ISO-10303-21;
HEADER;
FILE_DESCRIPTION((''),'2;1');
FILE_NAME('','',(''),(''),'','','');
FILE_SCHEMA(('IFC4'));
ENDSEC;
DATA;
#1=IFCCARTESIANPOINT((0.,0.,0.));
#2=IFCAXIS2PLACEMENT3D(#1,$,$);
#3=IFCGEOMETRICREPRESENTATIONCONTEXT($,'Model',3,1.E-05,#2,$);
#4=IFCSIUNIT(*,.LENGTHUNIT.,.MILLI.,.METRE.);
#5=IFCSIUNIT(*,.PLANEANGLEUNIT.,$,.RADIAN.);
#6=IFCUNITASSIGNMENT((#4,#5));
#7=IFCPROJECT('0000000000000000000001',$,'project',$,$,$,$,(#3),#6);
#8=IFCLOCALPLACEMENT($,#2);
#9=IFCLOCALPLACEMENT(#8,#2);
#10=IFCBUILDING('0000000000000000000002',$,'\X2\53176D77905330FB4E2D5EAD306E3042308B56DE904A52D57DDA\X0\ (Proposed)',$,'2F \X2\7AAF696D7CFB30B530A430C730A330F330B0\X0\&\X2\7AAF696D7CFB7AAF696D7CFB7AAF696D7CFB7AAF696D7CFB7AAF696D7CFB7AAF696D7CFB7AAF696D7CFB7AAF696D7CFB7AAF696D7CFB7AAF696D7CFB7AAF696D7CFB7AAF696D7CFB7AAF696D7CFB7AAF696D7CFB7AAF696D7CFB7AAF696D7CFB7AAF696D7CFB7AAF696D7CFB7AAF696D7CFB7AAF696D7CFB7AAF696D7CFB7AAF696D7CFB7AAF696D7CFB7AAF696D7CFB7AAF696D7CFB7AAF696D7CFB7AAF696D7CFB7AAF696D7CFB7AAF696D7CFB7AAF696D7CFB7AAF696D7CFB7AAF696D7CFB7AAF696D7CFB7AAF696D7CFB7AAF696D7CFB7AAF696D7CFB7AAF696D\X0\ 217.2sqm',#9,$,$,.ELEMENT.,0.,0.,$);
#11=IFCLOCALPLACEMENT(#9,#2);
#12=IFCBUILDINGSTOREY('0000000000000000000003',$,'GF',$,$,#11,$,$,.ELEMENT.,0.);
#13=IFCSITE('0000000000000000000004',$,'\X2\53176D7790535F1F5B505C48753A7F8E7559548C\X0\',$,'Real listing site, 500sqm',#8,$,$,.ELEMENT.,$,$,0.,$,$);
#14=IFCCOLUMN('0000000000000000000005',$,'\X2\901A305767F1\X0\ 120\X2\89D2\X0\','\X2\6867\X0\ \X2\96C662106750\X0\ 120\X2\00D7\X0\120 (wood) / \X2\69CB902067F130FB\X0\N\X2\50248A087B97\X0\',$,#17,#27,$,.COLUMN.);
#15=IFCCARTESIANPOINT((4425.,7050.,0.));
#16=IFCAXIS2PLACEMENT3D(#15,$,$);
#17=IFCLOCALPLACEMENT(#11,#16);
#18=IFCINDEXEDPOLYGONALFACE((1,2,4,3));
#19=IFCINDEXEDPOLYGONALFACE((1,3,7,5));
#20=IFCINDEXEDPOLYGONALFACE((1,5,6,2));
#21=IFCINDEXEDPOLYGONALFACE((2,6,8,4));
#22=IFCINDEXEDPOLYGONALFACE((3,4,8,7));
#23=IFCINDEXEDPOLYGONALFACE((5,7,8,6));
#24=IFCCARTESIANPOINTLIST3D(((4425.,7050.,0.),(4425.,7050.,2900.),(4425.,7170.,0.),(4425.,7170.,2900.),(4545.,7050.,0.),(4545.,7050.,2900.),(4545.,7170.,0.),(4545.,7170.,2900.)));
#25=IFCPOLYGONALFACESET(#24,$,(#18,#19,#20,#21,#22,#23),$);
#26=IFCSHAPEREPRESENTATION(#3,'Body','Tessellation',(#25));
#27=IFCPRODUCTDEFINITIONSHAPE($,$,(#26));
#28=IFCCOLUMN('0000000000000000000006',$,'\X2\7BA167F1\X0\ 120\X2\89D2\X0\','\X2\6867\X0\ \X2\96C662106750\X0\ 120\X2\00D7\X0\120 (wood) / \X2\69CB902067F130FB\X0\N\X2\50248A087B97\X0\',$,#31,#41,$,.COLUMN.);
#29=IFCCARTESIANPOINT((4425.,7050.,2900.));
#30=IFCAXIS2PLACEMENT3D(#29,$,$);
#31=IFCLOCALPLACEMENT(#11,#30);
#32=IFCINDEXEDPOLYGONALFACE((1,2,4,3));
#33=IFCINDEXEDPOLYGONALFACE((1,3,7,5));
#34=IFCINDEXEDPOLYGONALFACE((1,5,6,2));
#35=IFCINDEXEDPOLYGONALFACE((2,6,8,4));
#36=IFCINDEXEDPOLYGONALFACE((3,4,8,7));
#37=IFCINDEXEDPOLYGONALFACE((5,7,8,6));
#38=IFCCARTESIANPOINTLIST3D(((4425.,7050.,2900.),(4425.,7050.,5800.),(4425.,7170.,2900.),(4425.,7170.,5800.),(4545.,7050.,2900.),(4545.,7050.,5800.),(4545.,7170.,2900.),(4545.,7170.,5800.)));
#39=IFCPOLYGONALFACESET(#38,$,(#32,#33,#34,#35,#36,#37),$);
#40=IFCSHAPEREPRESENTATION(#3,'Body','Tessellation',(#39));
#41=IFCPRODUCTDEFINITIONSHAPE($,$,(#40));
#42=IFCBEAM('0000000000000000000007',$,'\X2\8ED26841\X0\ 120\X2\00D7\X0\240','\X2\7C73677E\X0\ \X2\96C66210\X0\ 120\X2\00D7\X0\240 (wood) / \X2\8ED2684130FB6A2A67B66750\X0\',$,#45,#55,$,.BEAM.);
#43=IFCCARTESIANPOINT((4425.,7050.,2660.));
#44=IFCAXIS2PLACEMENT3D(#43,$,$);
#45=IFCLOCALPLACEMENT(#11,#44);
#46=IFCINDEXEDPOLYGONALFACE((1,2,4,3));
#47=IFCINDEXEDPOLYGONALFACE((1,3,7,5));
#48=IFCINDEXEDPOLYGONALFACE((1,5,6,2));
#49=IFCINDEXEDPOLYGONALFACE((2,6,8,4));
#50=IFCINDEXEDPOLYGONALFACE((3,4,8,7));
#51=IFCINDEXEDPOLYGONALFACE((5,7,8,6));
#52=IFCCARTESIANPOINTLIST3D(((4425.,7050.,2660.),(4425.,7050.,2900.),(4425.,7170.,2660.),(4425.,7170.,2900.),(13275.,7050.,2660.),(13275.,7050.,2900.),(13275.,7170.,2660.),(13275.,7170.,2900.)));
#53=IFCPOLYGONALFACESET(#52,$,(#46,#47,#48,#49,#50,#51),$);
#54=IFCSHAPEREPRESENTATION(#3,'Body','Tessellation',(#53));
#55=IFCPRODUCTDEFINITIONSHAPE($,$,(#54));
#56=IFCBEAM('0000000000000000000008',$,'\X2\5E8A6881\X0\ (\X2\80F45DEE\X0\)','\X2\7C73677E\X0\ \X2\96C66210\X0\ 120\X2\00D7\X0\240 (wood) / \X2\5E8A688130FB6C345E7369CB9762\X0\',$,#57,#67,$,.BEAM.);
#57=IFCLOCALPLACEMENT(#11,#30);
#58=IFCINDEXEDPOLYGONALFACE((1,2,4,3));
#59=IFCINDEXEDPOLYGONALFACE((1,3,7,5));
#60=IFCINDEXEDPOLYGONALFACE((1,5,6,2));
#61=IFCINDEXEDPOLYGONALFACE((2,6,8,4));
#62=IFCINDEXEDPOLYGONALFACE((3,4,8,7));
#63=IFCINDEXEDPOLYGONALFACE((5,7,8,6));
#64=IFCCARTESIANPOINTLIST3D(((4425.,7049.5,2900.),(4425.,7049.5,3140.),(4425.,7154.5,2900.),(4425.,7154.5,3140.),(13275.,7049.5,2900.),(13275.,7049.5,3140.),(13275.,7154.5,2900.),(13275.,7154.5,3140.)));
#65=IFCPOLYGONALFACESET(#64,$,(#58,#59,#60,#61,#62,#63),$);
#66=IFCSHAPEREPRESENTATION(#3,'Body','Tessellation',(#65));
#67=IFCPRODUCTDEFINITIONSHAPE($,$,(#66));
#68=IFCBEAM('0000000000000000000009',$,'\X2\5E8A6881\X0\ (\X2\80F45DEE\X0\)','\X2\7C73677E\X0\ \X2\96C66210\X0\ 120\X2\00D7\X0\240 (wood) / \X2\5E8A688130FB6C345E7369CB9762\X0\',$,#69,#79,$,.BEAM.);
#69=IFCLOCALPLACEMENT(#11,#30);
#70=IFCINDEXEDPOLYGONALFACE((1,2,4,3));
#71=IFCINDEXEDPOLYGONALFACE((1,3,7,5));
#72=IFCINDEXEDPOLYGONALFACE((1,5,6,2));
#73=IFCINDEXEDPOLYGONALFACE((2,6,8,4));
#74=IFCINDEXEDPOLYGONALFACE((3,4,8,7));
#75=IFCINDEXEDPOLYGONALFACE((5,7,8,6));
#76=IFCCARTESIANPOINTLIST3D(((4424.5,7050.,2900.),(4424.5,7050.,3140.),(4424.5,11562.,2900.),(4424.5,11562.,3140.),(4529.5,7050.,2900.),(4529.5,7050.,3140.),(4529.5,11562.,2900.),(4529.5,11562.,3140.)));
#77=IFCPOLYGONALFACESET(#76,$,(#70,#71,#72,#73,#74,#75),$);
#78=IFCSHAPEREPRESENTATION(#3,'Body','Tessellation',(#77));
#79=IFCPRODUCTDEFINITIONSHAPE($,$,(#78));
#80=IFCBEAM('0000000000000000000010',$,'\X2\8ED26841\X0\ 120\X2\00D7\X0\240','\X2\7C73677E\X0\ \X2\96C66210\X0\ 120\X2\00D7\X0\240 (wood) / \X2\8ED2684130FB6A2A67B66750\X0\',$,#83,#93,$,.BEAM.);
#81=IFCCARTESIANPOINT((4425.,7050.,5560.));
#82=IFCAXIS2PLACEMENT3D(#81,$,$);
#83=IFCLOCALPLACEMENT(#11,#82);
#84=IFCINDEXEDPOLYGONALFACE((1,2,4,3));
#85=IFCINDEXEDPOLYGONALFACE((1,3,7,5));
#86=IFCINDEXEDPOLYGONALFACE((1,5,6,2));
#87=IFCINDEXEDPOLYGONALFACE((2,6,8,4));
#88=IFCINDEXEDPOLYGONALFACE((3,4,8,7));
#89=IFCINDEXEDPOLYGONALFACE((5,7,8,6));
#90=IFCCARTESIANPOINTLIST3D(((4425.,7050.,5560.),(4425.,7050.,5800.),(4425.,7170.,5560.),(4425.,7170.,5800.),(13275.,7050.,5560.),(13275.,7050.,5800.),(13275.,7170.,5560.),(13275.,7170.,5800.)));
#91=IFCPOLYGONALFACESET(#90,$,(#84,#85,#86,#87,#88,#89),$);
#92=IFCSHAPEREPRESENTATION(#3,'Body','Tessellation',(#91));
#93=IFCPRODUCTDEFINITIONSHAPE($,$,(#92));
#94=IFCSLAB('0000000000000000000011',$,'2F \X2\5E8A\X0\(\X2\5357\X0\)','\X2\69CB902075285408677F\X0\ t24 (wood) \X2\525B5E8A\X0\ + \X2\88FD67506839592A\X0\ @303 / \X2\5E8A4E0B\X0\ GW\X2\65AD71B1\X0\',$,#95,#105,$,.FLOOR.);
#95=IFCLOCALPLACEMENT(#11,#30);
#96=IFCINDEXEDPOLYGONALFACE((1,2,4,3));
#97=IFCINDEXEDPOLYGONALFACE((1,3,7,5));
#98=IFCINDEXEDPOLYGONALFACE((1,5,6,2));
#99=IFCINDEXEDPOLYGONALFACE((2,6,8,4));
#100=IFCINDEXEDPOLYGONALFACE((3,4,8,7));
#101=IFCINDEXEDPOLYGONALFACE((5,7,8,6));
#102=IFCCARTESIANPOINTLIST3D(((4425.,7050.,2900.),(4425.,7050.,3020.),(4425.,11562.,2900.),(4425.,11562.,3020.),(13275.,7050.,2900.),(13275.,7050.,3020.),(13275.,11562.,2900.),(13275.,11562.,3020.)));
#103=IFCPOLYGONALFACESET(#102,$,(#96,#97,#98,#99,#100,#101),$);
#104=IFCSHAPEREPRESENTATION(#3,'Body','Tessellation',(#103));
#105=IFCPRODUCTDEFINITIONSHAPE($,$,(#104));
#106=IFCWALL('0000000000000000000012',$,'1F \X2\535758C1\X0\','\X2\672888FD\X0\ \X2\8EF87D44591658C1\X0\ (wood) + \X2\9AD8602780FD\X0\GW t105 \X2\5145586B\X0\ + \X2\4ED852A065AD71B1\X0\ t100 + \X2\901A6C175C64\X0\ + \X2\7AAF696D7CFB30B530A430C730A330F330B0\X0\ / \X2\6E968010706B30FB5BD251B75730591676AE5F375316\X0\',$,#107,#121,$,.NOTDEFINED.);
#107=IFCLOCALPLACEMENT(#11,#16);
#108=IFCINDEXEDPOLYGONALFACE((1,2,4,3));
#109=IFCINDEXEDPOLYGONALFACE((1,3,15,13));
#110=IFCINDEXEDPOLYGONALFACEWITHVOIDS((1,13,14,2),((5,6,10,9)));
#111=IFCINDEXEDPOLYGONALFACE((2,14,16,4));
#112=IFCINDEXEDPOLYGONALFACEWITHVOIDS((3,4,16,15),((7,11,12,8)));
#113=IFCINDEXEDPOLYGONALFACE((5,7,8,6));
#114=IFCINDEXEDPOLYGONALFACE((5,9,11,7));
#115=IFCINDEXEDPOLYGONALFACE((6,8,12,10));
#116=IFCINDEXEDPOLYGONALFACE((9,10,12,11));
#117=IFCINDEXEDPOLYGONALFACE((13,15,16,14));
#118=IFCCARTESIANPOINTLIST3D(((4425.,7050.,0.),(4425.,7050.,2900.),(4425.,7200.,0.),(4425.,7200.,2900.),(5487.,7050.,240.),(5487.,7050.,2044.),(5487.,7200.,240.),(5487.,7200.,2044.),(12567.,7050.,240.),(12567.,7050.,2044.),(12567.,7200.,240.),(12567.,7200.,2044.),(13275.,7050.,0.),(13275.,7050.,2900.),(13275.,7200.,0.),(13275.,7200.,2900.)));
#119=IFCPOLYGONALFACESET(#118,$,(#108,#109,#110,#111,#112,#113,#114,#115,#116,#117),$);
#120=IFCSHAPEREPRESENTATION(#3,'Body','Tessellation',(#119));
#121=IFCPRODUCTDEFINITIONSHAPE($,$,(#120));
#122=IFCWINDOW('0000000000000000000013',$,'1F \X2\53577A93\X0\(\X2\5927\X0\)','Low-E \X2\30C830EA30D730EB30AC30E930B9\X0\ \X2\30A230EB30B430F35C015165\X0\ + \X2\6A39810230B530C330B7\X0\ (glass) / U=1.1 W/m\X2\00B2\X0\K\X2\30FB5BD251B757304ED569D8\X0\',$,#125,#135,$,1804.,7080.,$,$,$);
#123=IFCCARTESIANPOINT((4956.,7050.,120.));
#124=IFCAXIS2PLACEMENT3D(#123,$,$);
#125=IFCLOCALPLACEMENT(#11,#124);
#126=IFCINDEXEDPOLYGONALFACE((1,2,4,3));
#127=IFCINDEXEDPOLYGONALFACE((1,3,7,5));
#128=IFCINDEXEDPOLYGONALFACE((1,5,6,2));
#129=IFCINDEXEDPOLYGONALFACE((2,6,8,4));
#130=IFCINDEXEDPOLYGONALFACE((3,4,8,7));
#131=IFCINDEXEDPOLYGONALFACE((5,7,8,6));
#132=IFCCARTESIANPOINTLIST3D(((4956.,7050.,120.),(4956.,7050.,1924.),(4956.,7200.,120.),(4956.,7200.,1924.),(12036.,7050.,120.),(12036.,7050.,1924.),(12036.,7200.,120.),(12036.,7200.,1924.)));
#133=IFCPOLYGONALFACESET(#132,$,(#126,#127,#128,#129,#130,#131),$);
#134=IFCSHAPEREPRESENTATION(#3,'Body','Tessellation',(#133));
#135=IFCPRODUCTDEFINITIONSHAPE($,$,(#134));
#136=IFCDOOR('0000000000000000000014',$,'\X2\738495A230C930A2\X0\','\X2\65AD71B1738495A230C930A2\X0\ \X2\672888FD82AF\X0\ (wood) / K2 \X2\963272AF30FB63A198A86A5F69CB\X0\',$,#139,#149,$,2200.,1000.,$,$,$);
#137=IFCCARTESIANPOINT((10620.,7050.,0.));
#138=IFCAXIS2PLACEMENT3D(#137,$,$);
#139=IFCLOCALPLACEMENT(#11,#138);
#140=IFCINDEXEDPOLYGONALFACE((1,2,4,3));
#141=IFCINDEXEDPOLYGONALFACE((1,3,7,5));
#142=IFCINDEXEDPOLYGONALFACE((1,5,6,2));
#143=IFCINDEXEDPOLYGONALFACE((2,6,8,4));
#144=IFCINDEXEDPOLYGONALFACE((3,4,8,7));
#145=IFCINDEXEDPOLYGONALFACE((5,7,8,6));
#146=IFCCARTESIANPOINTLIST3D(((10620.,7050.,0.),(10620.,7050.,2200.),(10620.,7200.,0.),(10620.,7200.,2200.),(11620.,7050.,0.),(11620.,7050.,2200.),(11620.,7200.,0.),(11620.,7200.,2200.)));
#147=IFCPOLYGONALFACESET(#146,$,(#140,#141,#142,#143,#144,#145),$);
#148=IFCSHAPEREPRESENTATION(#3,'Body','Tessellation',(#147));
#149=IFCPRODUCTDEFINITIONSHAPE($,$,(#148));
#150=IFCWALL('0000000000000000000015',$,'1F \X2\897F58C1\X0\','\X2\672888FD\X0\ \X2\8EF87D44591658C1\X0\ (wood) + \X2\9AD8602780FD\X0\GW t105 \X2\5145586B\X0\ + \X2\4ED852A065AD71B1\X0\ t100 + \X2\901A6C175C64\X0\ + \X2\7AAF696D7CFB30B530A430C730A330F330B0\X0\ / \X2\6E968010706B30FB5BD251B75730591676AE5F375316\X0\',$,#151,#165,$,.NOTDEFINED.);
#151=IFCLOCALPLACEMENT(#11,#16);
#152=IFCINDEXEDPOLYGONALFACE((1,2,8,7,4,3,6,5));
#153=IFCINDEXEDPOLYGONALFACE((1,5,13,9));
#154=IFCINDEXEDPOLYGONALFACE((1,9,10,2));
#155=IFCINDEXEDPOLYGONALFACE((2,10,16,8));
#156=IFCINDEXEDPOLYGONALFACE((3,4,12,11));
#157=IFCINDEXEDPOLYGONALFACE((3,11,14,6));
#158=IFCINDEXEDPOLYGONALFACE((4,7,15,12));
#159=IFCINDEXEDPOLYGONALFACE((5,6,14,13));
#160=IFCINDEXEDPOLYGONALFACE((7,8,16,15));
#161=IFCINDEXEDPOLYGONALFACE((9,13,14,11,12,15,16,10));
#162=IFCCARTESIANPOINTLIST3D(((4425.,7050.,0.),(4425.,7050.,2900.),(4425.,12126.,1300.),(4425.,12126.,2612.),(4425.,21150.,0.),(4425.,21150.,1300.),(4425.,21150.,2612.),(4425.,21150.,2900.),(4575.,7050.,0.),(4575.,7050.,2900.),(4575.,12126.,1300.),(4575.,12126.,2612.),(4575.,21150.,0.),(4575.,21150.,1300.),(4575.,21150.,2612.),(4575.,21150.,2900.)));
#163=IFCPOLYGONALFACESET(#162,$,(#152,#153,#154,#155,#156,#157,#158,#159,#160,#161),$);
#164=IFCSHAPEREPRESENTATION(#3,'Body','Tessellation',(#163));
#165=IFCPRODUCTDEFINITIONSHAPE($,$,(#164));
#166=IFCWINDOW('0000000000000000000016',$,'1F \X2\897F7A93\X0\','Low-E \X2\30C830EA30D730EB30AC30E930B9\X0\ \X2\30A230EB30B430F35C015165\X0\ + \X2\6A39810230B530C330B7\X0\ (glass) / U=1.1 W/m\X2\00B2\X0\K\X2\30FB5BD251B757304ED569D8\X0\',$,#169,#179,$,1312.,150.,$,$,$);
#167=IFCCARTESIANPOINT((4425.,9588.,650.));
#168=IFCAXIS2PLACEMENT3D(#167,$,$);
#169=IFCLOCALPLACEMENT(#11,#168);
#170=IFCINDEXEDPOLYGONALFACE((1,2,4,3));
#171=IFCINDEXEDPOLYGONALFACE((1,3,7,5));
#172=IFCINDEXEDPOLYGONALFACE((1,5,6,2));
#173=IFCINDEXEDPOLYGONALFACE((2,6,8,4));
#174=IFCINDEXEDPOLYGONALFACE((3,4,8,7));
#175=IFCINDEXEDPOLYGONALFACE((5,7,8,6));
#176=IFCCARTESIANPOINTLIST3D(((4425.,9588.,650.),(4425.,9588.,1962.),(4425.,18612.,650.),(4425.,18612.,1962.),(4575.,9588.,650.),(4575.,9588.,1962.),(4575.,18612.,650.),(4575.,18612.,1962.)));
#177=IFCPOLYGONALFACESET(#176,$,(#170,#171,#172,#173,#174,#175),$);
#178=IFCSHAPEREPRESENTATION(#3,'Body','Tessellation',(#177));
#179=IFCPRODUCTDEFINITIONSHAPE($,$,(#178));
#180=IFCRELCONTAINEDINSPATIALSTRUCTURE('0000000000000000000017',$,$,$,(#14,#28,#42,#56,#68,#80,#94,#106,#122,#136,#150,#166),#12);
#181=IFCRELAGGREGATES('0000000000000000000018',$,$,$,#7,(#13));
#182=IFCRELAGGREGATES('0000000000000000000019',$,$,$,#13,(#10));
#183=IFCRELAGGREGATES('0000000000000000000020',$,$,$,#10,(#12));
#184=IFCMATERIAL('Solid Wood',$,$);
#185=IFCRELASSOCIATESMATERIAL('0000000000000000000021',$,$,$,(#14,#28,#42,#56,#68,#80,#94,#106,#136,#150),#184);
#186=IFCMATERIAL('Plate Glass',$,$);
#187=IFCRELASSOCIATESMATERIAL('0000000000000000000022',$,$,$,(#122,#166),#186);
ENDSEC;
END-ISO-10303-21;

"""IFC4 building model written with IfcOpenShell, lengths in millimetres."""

from ifc_helpers import new_model, si_unit, frame, frame_2d, origin, place, context, project, spatial, rectangle, extrude, material, element, fill, save


model = new_model("IFC4")

# Units and contexts
model_context = context("Model", 3, precision=1e-05, world=origin())
ifc_project = project(units=[si_unit("LENGTHUNIT", "METRE", prefix="MILLI"), si_unit("PLANEANGLEUNIT", "RADIAN")], contexts=[model_context])

# Site, building, storey
site_placement = place(None, origin())
site = spatial("IfcSite", under=ifc_project, at=site_placement, Name="北海道弟子屈町美留和", ObjectType="Real listing site, 500sqm", CompositionType="ELEMENT", RefElevation=0.0)
building_placement = place(site_placement, origin())
building = spatial("IfcBuilding", under=site, at=building_placement, Name="北海道・中庭のある回遊動線 (Proposed)", ObjectType="2F 窯業系サイディング&窯業系窯業系窯業系窯業系窯業系窯業系窯業系窯業系窯業系窯業系窯業系窯業系窯業系窯業系窯業系窯業系窯業系窯業系窯業系窯業系窯業系窯業系窯業系窯業系窯業系窯業系窯業系窯業系窯業系窯業系窯業系窯業系窯業系窯業系窯業系窯業系窯業 217.2sqm", CompositionType="ELEMENT", ElevationOfRefHeight=0.0, ElevationOfTerrain=0.0)
storey_placement = place(building_placement, origin())
storey = spatial("IfcBuildingStorey", under=building, at=storey_placement, Name="GF", CompositionType="ELEMENT", Elevation=0.0)

# Columns
ifc_material_1 = material(Name="Solid Wood")
column_1_placement = place(storey_placement, frame((4425.0, 7050.0, 0.0)))
element("IfcColumn", 1, at=column_1_placement, inside=storey, material=ifc_material_1, Name="通し柱 120角", Description="桧 集成材 120×120 (wood) / 構造柱・N値計算", PredefinedType="COLUMN", context=model_context, shape_type="SweptSolid", body=[
    extrude(rectangle(XDim=120.0, YDim=120.0, at=frame_2d((60.0, 60.0))), frame((4425.0, 7050.0, 0.0)), (0.0, 0.0, 1.0), 2900.0),
])
column_2_placement = place(storey_placement, frame((4425.0, 7050.0, 2900.0)))
element("IfcColumn", 2, at=column_2_placement, inside=storey, material=ifc_material_1, Name="管柱 120角", Description="桧 集成材 120×120 (wood) / 構造柱・N値計算", PredefinedType="COLUMN", context=model_context, shape_type="SweptSolid", body=[
    extrude(rectangle(XDim=120.0, YDim=120.0, at=frame_2d((60.0, 60.0))), frame((4425.0, 7050.0, 2900.0)), (0.0, 0.0, 1.0), 2900.0),
])

# Beams
beam_1_placement = place(storey_placement, frame((4425.0, 7050.0, 2660.0)))
element("IfcBeam", 3, at=beam_1_placement, inside=storey, material=ifc_material_1, Name="軒桁 120×240", Description="米松 集成 120×240 (wood) / 軒桁・横架材", PredefinedType="BEAM", context=model_context, shape_type="SweptSolid", body=[
    extrude(rectangle(XDim=8850.0, YDim=120.0, at=frame_2d((4425.0, 60.0))), frame((4425.0, 7050.0, 2660.0)), (0.0, 0.0, 1.0), 240.0),
])
beam_2_placement = place(storey_placement, frame((4425.0, 7050.0, 2900.0)))
element("IfcBeam", 4, at=beam_2_placement, inside=storey, material=ifc_material_1, Name="床梁 (胴差)", Description="米松 集成 120×240 (wood) / 床梁・水平構面", PredefinedType="BEAM", context=model_context, shape_type="SweptSolid", body=[
    extrude(rectangle(XDim=8850.0, YDim=105.0, at=frame_2d((4425.0, 52.0))), frame((4425.0, 7050.0, 2900.0)), (0.0, 0.0, 1.0), 240.0),
])
beam_3_placement = place(storey_placement, frame((4425.0, 7050.0, 2900.0)))
element("IfcBeam", 5, at=beam_3_placement, inside=storey, material=ifc_material_1, Name="床梁 (胴差)", Description="米松 集成 120×240 (wood) / 床梁・水平構面", PredefinedType="BEAM", context=model_context, shape_type="SweptSolid", body=[
    extrude(rectangle(XDim=105.0, YDim=4512.0, at=frame_2d((52.0, 2256.0))), frame((4425.0, 7050.0, 2900.0)), (0.0, 0.0, 1.0), 240.0),
])
beam_4_placement = place(storey_placement, frame((4425.0, 7050.0, 5560.0)))
element("IfcBeam", 6, at=beam_4_placement, inside=storey, material=ifc_material_1, Name="軒桁 120×240", Description="米松 集成 120×240 (wood) / 軒桁・横架材", PredefinedType="BEAM", context=model_context, shape_type="SweptSolid", body=[
    extrude(rectangle(XDim=8850.0, YDim=120.0, at=frame_2d((4425.0, 60.0))), frame((4425.0, 7050.0, 5560.0)), (0.0, 0.0, 1.0), 240.0),
])

# Slab
slab_1_placement = place(storey_placement, frame((4425.0, 7050.0, 2900.0)))
element("IfcSlab", 7, at=slab_1_placement, inside=storey, material=ifc_material_1, Name="2F 床(南)", Description="構造用合板 t24 (wood) 剛床 + 製材根太 @303 / 床下 GW断熱", PredefinedType="FLOOR", context=model_context, shape_type="SweptSolid", body=[
    extrude(rectangle(XDim=8850.0, YDim=4512.0, at=frame_2d((4425.0, 2256.0))), frame((4425.0, 7050.0, 2900.0)), (0.0, 0.0, 1.0), 120.0),
])

# Wall, openings, window, door
wall_1_placement = place(storey_placement, frame((4425.0, 7050.0, 0.0)))
wall_1 = element("IfcWall", 8, at=wall_1_placement, inside=storey, material=ifc_material_1, Name="1F 南壁", Description="木製 軸組外壁 (wood) + 高性能GW t105 充填 + 付加断熱 t100 + 通気層 + 窯業系サイディング / 準耐火・寒冷地外皮強化", PredefinedType="NOTDEFINED", context=model_context, shape_type="SweptSolid", body=[
    extrude(rectangle(XDim=8850.0, YDim=150.0, at=frame_2d((4425.0, 75.0))), frame((4425.0, 7050.0, 0.0)), (0.0, 0.0, 1.0), 2900.0),
])
opening_1_placement = place(storey_placement, frame((4956.0, 7050.0, 120.0)))
opening_1 = element("IfcOpeningElement", 9, at=opening_1_placement, cuts=wall_1, PredefinedType="NOTDEFINED", context=model_context, shape_type="SweptSolid", body=[
    extrude(rectangle(XDim=7080.0, YDim=150.0, at=frame_2d((3540.0, 75.0))), frame((4956.0, 7050.0, 120.0)), (0.0, 0.0, 1.0), 1804.0),
])
opening_2_placement = place(storey_placement, frame((10620.0, 7050.0, 0.0)))
opening_2 = element("IfcOpeningElement", 10, at=opening_2_placement, cuts=wall_1, PredefinedType="NOTDEFINED", context=model_context, shape_type="SweptSolid", body=[
    extrude(rectangle(XDim=1000.0, YDim=150.0, at=frame_2d((500.0, 75.0))), frame((10620.0, 7050.0, 0.0)), (0.0, 0.0, 1.0), 2200.0),
])
ifc_material_2 = material(Name="Plate Glass")
window_1_placement = place(storey_placement, frame((4956.0, 7050.0, 120.0)))
window_1 = element("IfcWindow", 11, at=window_1_placement, inside=storey, material=ifc_material_2, Name="1F 南窓(大)", Description="Low-E トリプルガラス アルゴン封入 + 樹脂サッシ (glass) / U=1.1 W/m²K・寒冷地仕様", OverallHeight=1804.0, OverallWidth=7080.0, context=model_context, shape_type="SweptSolid", body=[
    extrude(rectangle(XDim=7080.0, YDim=150.0, at=frame_2d((3540.0, 75.0))), frame((4956.0, 7050.0, 120.0)), (0.0, 0.0, 1.0), 1804.0),
])
fill(opening_1, window_1)
door_placement = place(storey_placement, frame((10620.0, 7050.0, 0.0)))
door = element("IfcDoor", 12, at=door_placement, inside=storey, material=ifc_material_1, Name="玄関ドア", Description="断熱玄関ドア 木製芯 (wood) / K2 防犯・採風機構", OverallHeight=2200.0, OverallWidth=1000.0, context=model_context, shape_type="SweptSolid", body=[
    extrude(rectangle(XDim=1000.0, YDim=150.0, at=frame_2d((500.0, 75.0))), frame((10620.0, 7050.0, 0.0)), (0.0, 0.0, 1.0), 2200.0),
])
fill(opening_2, door)

# Wall, opening, window
wall_2_placement = place(storey_placement, frame((4425.0, 7050.0, 0.0)))
wall_2 = element("IfcWall", 13, at=wall_2_placement, inside=storey, material=ifc_material_1, Name="1F 西壁", Description="木製 軸組外壁 (wood) + 高性能GW t105 充填 + 付加断熱 t100 + 通気層 + 窯業系サイディング / 準耐火・寒冷地外皮強化", PredefinedType="NOTDEFINED", context=model_context, shape_type="SweptSolid", body=[
    extrude(rectangle(XDim=150.0, YDim=14100.0, at=frame_2d((75.0, 7050.0))), frame((4425.0, 7050.0, 0.0)), (0.0, 0.0, 1.0), 2900.0),
])
opening_3_placement = place(storey_placement, frame((4425.0, 9588.0, 650.0)))
opening_3 = element("IfcOpeningElement", 14, at=opening_3_placement, cuts=wall_2, PredefinedType="NOTDEFINED", context=model_context, shape_type="SweptSolid", body=[
    extrude(rectangle(XDim=150.0, YDim=9024.0, at=frame_2d((75.0, 4512.0))), frame((4425.0, 9588.0, 650.0)), (0.0, 0.0, 1.0), 1312.0),
])
window_2_placement = place(storey_placement, frame((4425.0, 9588.0, 650.0)))
window_2 = element("IfcWindow", 15, at=window_2_placement, inside=storey, material=ifc_material_2, Name="1F 西窓", Description="Low-E トリプルガラス アルゴン封入 + 樹脂サッシ (glass) / U=1.1 W/m²K・寒冷地仕様", OverallHeight=1312.0, OverallWidth=150.0, context=model_context, shape_type="SweptSolid", body=[
    extrude(rectangle(XDim=150.0, YDim=9024.0, at=frame_2d((75.0, 4512.0))), frame((4425.0, 9588.0, 650.0)), (0.0, 0.0, 1.0), 1312.0),
])
fill(opening_3, window_2)

save(model, "model.ifc")
